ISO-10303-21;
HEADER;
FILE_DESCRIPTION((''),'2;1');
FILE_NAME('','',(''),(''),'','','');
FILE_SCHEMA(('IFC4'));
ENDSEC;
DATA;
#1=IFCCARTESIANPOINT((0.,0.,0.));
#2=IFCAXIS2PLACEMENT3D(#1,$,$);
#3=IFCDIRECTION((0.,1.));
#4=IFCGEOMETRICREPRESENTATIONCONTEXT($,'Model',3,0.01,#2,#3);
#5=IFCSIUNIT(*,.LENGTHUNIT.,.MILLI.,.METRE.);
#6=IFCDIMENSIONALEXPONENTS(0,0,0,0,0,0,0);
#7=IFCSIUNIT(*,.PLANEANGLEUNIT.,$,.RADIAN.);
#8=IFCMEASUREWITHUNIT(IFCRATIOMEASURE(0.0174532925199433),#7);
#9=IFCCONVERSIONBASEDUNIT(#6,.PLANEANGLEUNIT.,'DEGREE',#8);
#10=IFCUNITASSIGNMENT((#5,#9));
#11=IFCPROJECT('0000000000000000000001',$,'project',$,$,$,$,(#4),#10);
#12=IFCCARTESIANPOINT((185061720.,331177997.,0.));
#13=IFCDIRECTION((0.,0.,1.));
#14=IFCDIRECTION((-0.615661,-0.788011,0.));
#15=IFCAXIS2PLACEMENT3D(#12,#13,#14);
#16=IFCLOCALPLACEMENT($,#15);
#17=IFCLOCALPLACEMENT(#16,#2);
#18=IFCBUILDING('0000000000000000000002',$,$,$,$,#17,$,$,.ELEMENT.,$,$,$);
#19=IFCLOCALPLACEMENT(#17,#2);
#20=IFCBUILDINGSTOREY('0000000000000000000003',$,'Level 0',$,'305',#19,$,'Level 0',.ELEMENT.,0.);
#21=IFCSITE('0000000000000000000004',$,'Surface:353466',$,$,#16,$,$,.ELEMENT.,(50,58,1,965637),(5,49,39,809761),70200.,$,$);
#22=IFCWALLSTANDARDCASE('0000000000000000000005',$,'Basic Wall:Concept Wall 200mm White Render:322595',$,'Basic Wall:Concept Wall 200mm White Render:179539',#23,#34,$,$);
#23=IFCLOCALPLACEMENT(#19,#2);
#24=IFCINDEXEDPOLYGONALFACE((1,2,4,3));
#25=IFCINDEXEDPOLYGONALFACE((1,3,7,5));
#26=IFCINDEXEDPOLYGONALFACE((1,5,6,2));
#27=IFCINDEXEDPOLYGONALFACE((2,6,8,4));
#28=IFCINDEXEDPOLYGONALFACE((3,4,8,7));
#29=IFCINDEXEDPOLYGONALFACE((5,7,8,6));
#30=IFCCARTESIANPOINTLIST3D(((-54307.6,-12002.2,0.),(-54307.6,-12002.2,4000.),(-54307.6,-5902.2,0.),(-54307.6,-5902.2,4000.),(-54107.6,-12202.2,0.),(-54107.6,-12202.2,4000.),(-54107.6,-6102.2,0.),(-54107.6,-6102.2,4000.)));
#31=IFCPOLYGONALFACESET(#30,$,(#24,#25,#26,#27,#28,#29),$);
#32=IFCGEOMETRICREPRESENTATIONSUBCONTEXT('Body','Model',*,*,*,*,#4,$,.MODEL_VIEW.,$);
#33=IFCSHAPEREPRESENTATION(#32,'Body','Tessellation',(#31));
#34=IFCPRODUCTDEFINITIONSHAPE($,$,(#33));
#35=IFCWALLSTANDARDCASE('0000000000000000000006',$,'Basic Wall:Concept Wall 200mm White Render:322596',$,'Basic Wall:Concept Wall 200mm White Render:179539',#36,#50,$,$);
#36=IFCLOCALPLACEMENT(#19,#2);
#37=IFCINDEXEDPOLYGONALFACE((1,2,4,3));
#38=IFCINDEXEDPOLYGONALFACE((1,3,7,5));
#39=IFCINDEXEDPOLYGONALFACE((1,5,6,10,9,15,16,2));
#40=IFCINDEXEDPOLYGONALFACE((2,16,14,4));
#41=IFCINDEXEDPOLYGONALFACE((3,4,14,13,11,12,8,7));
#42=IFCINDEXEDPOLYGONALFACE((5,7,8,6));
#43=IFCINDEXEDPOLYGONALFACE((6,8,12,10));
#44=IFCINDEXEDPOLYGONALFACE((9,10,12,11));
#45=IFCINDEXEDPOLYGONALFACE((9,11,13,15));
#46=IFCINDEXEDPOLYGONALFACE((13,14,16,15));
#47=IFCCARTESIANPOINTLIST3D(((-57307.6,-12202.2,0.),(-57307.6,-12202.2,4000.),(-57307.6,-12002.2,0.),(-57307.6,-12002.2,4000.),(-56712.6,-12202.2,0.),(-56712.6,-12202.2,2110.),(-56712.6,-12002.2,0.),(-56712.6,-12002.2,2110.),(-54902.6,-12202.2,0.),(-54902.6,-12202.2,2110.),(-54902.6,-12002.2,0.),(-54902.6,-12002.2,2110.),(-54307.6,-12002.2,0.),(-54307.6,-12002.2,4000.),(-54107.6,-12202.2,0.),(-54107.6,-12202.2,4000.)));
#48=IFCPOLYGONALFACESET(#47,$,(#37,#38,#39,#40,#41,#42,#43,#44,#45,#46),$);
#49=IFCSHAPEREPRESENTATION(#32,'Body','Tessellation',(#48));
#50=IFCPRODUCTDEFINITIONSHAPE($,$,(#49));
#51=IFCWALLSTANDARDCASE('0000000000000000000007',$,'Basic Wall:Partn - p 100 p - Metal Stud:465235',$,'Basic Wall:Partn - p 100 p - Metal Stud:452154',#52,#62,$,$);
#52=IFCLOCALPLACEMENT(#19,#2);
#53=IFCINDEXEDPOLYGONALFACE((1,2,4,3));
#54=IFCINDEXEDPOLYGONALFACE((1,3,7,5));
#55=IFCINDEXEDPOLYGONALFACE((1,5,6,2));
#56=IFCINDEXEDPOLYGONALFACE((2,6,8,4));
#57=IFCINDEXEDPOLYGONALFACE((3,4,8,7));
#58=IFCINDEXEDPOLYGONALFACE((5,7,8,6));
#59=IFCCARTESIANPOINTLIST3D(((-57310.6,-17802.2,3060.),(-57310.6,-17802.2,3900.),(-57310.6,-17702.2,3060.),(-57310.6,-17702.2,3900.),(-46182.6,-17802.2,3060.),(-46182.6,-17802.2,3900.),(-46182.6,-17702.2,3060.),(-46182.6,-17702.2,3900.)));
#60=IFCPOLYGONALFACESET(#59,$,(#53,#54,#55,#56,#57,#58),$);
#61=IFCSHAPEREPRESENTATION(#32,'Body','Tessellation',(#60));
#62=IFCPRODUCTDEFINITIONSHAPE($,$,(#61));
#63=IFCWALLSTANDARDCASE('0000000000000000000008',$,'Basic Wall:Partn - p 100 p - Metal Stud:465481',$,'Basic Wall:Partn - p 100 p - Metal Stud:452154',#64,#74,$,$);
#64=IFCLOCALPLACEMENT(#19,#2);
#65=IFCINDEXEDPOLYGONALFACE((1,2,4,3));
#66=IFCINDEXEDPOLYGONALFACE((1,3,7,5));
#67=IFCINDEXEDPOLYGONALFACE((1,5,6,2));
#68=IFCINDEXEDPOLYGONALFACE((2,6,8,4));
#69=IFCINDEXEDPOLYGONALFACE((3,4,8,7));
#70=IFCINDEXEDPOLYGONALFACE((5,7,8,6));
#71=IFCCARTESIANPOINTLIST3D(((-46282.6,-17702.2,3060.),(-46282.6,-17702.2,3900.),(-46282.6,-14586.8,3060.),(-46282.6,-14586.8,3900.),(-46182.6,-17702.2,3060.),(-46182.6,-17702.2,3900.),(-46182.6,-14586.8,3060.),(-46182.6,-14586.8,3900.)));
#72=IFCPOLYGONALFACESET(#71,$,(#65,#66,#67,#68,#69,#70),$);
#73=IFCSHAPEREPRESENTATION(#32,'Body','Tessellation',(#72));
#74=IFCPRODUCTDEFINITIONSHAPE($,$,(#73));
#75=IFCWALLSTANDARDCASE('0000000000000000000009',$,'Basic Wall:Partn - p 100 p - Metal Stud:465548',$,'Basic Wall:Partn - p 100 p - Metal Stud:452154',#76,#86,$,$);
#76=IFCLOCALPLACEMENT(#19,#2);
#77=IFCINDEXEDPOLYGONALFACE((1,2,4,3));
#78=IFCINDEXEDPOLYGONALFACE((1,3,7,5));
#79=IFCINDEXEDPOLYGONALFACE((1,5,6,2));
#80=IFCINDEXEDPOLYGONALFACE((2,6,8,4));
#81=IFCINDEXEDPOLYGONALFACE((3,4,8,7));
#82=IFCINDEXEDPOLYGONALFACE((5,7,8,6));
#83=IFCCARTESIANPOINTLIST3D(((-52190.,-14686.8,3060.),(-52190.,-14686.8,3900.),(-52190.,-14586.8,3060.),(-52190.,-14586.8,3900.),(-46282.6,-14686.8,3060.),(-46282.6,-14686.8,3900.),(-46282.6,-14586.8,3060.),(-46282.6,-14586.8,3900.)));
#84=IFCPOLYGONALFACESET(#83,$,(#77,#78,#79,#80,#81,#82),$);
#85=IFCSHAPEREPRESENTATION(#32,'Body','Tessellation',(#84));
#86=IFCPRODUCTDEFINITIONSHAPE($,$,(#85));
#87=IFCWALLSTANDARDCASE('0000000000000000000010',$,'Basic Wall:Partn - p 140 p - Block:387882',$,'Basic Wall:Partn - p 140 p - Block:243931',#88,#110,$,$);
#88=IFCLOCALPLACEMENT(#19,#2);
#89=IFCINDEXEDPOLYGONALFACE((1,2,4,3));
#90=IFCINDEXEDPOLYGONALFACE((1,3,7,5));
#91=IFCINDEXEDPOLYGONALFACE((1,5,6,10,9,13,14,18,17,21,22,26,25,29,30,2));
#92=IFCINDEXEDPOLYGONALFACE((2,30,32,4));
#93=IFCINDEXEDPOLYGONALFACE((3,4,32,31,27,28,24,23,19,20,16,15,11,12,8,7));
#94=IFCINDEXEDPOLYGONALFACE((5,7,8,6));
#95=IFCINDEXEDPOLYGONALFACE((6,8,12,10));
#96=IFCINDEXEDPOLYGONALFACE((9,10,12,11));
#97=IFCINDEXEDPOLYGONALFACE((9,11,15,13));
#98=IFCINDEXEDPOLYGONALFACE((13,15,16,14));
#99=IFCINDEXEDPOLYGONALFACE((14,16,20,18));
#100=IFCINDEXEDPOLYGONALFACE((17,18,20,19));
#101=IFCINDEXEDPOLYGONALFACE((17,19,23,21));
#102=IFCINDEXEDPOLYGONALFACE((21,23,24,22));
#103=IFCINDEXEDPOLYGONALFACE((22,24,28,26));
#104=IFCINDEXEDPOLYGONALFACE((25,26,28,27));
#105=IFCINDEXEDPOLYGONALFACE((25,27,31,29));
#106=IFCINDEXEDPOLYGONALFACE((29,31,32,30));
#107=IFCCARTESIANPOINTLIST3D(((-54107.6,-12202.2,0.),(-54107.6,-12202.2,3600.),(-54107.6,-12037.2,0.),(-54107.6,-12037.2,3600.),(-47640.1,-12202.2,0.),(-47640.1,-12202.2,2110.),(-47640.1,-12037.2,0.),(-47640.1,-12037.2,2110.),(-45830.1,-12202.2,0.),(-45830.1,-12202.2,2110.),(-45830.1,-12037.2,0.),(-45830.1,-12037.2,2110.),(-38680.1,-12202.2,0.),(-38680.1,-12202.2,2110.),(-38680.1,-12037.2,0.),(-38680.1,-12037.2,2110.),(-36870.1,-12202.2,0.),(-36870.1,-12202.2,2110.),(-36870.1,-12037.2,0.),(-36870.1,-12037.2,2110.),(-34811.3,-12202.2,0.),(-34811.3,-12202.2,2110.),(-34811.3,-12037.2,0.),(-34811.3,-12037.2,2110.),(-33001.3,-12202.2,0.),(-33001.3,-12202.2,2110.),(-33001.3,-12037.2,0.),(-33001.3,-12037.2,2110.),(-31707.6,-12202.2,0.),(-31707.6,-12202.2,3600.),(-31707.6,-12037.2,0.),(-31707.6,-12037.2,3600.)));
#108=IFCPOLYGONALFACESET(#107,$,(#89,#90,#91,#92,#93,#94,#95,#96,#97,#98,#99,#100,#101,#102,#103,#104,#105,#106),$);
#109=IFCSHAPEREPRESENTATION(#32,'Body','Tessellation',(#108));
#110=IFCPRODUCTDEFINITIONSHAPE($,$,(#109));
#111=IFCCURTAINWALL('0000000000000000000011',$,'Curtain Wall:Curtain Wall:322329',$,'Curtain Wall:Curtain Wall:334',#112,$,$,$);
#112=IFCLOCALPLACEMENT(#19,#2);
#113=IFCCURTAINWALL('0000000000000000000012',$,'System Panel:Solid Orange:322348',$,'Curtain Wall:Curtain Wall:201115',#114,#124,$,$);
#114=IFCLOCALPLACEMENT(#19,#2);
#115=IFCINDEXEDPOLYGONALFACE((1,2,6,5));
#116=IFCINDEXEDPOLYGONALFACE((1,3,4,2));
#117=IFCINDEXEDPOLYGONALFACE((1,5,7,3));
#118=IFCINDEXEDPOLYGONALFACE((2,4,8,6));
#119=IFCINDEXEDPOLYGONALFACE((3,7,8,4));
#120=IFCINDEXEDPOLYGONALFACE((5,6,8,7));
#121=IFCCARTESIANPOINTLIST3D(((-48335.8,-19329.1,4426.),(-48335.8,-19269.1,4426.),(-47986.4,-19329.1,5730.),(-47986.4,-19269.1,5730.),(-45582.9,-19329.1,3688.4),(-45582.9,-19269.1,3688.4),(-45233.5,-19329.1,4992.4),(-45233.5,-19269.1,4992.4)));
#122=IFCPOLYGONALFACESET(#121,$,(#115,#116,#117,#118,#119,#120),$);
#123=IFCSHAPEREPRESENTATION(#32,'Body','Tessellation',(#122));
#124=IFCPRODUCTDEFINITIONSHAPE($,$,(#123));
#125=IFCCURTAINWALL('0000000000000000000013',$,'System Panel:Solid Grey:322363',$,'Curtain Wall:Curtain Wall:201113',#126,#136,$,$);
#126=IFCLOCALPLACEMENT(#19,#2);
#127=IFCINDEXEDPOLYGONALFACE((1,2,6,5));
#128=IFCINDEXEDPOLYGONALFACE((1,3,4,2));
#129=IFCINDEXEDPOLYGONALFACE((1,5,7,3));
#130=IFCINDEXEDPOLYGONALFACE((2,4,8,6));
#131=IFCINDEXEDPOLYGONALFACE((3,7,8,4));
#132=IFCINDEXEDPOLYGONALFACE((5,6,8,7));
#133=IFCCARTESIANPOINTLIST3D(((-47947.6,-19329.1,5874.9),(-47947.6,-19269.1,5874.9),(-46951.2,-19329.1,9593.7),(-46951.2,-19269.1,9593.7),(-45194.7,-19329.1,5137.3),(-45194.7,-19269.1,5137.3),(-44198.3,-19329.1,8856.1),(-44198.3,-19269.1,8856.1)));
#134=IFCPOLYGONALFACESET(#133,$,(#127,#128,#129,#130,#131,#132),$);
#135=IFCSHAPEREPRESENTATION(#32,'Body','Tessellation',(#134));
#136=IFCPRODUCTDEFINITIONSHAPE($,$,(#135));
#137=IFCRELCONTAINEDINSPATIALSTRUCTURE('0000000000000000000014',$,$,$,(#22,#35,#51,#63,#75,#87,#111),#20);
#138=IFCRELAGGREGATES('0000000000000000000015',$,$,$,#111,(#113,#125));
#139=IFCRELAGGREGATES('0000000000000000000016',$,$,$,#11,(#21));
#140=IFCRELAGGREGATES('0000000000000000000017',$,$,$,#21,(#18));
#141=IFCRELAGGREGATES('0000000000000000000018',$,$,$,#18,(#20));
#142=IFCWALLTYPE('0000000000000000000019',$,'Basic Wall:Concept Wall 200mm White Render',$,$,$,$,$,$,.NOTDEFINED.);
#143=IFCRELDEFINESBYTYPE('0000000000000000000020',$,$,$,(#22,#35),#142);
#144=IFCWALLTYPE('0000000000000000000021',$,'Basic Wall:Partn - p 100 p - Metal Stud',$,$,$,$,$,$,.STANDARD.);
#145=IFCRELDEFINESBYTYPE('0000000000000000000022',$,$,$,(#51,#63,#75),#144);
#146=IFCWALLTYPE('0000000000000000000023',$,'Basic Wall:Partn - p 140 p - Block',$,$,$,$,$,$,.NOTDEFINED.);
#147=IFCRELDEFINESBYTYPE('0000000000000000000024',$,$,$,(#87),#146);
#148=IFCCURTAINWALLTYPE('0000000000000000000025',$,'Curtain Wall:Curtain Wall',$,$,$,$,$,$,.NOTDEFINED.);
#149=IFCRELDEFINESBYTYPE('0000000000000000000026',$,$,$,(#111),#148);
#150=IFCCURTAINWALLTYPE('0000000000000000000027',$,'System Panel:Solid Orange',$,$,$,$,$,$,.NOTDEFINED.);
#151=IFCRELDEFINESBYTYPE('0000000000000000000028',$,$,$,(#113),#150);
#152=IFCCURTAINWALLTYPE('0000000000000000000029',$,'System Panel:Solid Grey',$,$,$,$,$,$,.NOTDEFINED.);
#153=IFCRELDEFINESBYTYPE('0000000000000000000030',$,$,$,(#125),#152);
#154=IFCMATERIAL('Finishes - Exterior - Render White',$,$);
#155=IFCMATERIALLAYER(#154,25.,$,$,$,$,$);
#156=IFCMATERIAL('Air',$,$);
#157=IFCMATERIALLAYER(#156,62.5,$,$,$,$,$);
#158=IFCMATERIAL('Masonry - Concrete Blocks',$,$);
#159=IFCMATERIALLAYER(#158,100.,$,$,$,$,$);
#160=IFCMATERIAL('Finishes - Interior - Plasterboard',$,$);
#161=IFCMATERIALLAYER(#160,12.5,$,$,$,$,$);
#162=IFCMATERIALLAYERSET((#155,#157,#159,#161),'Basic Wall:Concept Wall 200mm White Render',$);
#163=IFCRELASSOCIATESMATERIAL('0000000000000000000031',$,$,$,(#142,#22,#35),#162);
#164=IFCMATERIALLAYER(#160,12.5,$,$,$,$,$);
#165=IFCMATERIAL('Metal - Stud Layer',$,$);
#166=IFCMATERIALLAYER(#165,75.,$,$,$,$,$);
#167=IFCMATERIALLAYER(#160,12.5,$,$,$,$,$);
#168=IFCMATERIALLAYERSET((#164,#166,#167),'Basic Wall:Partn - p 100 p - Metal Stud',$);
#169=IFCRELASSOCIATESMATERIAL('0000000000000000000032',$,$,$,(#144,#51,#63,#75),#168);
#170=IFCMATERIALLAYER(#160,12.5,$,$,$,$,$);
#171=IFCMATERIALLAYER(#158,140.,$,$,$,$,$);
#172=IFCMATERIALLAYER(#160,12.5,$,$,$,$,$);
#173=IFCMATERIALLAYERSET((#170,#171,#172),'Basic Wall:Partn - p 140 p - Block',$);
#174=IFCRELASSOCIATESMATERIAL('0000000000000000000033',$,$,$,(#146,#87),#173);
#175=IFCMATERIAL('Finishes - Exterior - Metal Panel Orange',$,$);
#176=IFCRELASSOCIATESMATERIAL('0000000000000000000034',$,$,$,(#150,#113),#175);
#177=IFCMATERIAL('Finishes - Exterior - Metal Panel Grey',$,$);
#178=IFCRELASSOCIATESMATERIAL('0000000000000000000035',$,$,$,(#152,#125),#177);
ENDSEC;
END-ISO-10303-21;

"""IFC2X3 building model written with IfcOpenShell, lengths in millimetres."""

from ifc_helpers import new_model, entity, si_unit, converted_unit, direction, frame, frame_2d, origin, place, context, subcontext, project, spatial, polyline, rectangle, outline, extrude, clip, halfspace, bounded_halfspace, source, transform, mapped, material, layer, layer_set, layer_usage, type_object, type_shapes, element, aggregate, save


model = new_model("IFC2X3")

# Units and contexts
model_context = context("Model", 3, precision=0.01, world=origin(), true_north=direction((0.0, 1.0)))
body_context = subcontext(model_context, "Body", "Model", "MODEL_VIEW")
ifc_project = project(units=[si_unit("LENGTHUNIT", "METRE", prefix="MILLI"), converted_unit("PLANEANGLEUNIT", "DEGREE", entity("IfcRatioMeasure", 0.0174532925199433), si_unit("PLANEANGLEUNIT", "RADIAN"), dimensions=[0, 0, 0, 0, 0, 0, 0])], contexts=[model_context])

# Site, building, storey
site_placement = place(None, frame((185061720.0, 331177997.0, 0.0), z_axis=(0.0, 0.0, 1.0), x_axis=(-0.615661, -0.788011, 0.0)))
site = spatial("IfcSite", under=ifc_project, at=site_placement, Name="Surface:353466", CompositionType="ELEMENT", RefLatitude=(50, 58, 1, 965637), RefLongitude=(5, 49, 39, 809761), RefElevation=70200.0)
building_placement = place(site_placement, origin())
building = spatial("IfcBuilding", under=site, at=building_placement, CompositionType="ELEMENT")
storey_placement = place(building_placement, origin())
storey = spatial("IfcBuildingStorey", under=building, at=storey_placement, Name="Level 0", ObjectType="305", LongName="Level 0", CompositionType="ELEMENT", Elevation=0.0)

# Wall
ifc_material_1 = material(Name="Finishes - Exterior - Render White")
ifc_layer_1 = layer(ifc_material_1, 25.0)
ifc_material_2 = material(Name="Air")
ifc_layer_2 = layer(ifc_material_2, 62.5)
ifc_material_3 = material(Name="Masonry - Concrete Blocks")
ifc_layer_3 = layer(ifc_material_3, 100.0)
ifc_material_4 = material(Name="Finishes - Interior - Plasterboard")
ifc_layer_4 = layer(ifc_material_4, 12.5)
ifc_layer_set_1 = layer_set([ifc_layer_1, ifc_layer_2, ifc_layer_3, ifc_layer_4], Name="Basic Wall:Concept Wall 200mm White Render")
ifc_layer_usage_1 = layer_usage(ifc_layer_set_1, "AXIS2", "POSITIVE", -100.0)
wall_type_1 = type_object("IfcWallType", Name="Basic Wall:Concept Wall 200mm White Render", PredefinedType="NOTDEFINED", material=ifc_layer_set_1)
wall_1_placement = place(storey_placement, frame((-54207.6, -5902.2, 0.0), z_axis=(0.0, 0.0, 1.0), x_axis=(0.0, -1.0, 0.0)))
element("IfcWallStandardCase", 1, at=wall_1_placement, inside=storey, type_object=wall_type_1, material=ifc_layer_usage_1, Name="Basic Wall:Concept Wall 200mm White Render:322595", ObjectType="Basic Wall:Concept Wall 200mm White Render:179539", context=body_context, shape_type="Clipping", body=[
    clip(extrude(outline(polyline([(6100.0, -100.0), (6300.0, 100.0), (6135.0, 100.0), (200.0, 100.0), (0.0, -100.0), (6100.0, -100.0)])), origin(), (0.0, 0.0, 1.0), 4000.0), halfspace(origin(), True)),
])

# Wall, openings
ifc_layer_usage_2 = layer_usage(ifc_layer_set_1, "AXIS2", "POSITIVE", -100.0)
wall_2_placement = place(storey_placement, frame((-54107.6, -12102.2, 0.0), z_axis=(0.0, 0.0, 1.0), x_axis=(-1.0, 0.0, 0.0)))
wall_2 = element("IfcWallStandardCase", 2, at=wall_2_placement, inside=storey, type_object=wall_type_1, material=ifc_layer_usage_2, Name="Basic Wall:Concept Wall 200mm White Render:322596", ObjectType="Basic Wall:Concept Wall 200mm White Render:179539", context=body_context, shape_type="Clipping", body=[
    clip(extrude(outline(polyline([(200.0, -100.0), (3200.0, -100.0), (3200.0, 100.0), (0.0, 100.0), (200.0, -100.0)])), origin(), (0.0, 0.0, 1.0), 4000.0), halfspace(origin(), True)),
])
opening_1_placement = place(wall_2_placement, origin())
element("IfcOpeningElement", 3, at=opening_1_placement, cuts=wall_2, ObjectType="Opening", context=body_context, shape_type="SweptSolid", body=[
    extrude(rectangle(XDim=2110.0, YDim=1810.0, at=frame_2d((0.0, 0.0), x_axis=(1.0, 0.0))), frame((1700.0, -1624.0, 1055.0), z_axis=(0.0, 1.0, 0.0), x_axis=(0.0, 0.0, -1.0)), (0.0, 0.0, 1.0), 3048.0),
])
opening_2_placement = place(wall_2_placement, frame((2605.0, 100.0, 0.0)))
element("IfcOpeningElement", 4, at=opening_2_placement, cuts=wall_2, ObjectType="Opening", context=body_context, shape_type="SweptSolid", body=[
    extrude(rectangle(XDim=2110.0, YDim=1810.0, at=frame_2d((1055.0, 905.0), x_axis=(-1.0, 0.0))), frame((0.0, 0.0, 0.0), z_axis=(0.0, -1.0, 0.0), x_axis=(0.0, 0.0, 1.0)), (0.0, 0.0, 1.0), 200.0),
])

# Walls
ifc_layer_5 = layer(ifc_material_4, 12.5)
ifc_material_5 = material(Name="Metal - Stud Layer")
ifc_layer_6 = layer(ifc_material_5, 75.0)
ifc_layer_7 = layer(ifc_material_4, 12.5)
ifc_layer_set_2 = layer_set([ifc_layer_5, ifc_layer_6, ifc_layer_7], Name="Basic Wall:Partn - p 100 p - Metal Stud")
ifc_layer_usage_3 = layer_usage(ifc_layer_set_2, "AXIS2", "NEGATIVE", 50.0)
wall_type_2 = type_object("IfcWallType", Name="Basic Wall:Partn - p 100 p - Metal Stud", PredefinedType="STANDARD", material=ifc_layer_set_2)
wall_3_placement = place(storey_placement, frame((-46182.6, -17752.2, 3060.0), z_axis=(0.0, 0.0, 1.0), x_axis=(-1.0, 0.0, 0.0)))
element("IfcWallStandardCase", 5, at=wall_3_placement, inside=storey, type_object=wall_type_2, material=ifc_layer_usage_3, Name="Basic Wall:Partn - p 100 p - Metal Stud:465235", ObjectType="Basic Wall:Partn - p 100 p - Metal Stud:452154", context=body_context, shape_type="SweptSolid", body=[
    extrude(rectangle(XDim=11128.0, YDim=100.0, at=frame_2d((5564.0, 0.0), x_axis=(-1.0, 0.0))), origin(), (0.0, 0.0, 1.0), 840.0),
])
ifc_layer_usage_4 = layer_usage(ifc_layer_set_2, "AXIS2", "NEGATIVE", 50.0)
wall_4_placement = place(storey_placement, frame((-46232.6, -14586.8, 3060.0), z_axis=(0.0, 0.0, 1.0), x_axis=(0.0, -1.0, 0.0)))
element("IfcWallStandardCase", 6, at=wall_4_placement, inside=storey, type_object=wall_type_2, material=ifc_layer_usage_4, Name="Basic Wall:Partn - p 100 p - Metal Stud:465481", ObjectType="Basic Wall:Partn - p 100 p - Metal Stud:452154", context=body_context, shape_type="SweptSolid", body=[
    extrude(rectangle(XDim=3115.5, YDim=100.0, at=frame_2d((1557.7, 0.0), x_axis=(-1.0, 0.0))), origin(), (0.0, 0.0, 1.0), 840.0),
])
ifc_layer_usage_5 = layer_usage(ifc_layer_set_2, "AXIS2", "NEGATIVE", 50.0)
wall_5_placement = place(storey_placement, frame((-52190.0, -14636.8, 3060.0)))
element("IfcWallStandardCase", 7, at=wall_5_placement, inside=storey, type_object=wall_type_2, material=ifc_layer_usage_5, Name="Basic Wall:Partn - p 100 p - Metal Stud:465548", ObjectType="Basic Wall:Partn - p 100 p - Metal Stud:452154", context=body_context, shape_type="SweptSolid", body=[
    extrude(rectangle(XDim=5907.5, YDim=100.0, at=frame_2d((2953.7, 0.0), x_axis=(-1.0, 0.0))), origin(), (0.0, 0.0, 1.0), 840.0),
])

# Wall, openings
ifc_layer_8 = layer(ifc_material_4, 12.5)
ifc_layer_9 = layer(ifc_material_3, 140.0)
ifc_layer_10 = layer(ifc_material_4, 12.5)
ifc_layer_set_3 = layer_set([ifc_layer_8, ifc_layer_9, ifc_layer_10], Name="Basic Wall:Partn - p 140 p - Block")
ifc_layer_usage_6 = layer_usage(ifc_layer_set_3, "AXIS2", "POSITIVE", -82.5)
wall_type_3 = type_object("IfcWallType", Name="Basic Wall:Partn - p 140 p - Block", PredefinedType="NOTDEFINED", material=ifc_layer_set_3)
wall_6_placement = place(storey_placement, frame((-54107.6, -12119.7, 0.0)))
wall_6 = element("IfcWallStandardCase", 8, at=wall_6_placement, inside=storey, type_object=wall_type_3, material=ifc_layer_usage_6, Name="Basic Wall:Partn - p 140 p - Block:387882", ObjectType="Basic Wall:Partn - p 140 p - Block:243931", context=body_context, shape_type="Clipping", body=[
    clip(extrude(rectangle(XDim=22400.0, YDim=165.0, at=frame_2d((11200.0, 0.0), x_axis=(-1.0, 0.0))), origin(), (0.0, 0.0, 1.0), 3600.0), bounded_halfspace(frame((0.0, -82.5, 3600.0), z_axis=(0.0, 0.0, -1.0), x_axis=(1.0, 0.0, 0.0)), True, frame((0.0, -82.5, 3600.0)), polyline([(0.0, 0.0), (22400.0, 0.0), (22400.0, 165.0), (17602.5, 165.0), (17437.5, 165.0), (9042.5, 165.0), (8877.5, 165.0), (0.0, 165.0), (0.0, 0.0)]))),
])
opening_3_placement = place(wall_6_placement, origin())
element("IfcOpeningElement", 9, at=opening_3_placement, cuts=wall_6, ObjectType="Opening", context=body_context, shape_type="SweptSolid", body=[
    extrude(rectangle(XDim=2110.0, YDim=1810.0, at=frame_2d((0.0, 0.0), x_axis=(0.0, 1.0))), frame((7372.5, -1441.5, 1055.0), z_axis=(0.0, 1.0, 0.0), x_axis=(-1.0, 0.0, 0.0)), (0.0, 0.0, 1.0), 3048.0),
])
opening_4_placement = place(wall_6_placement, origin())
element("IfcOpeningElement", 10, at=opening_4_placement, cuts=wall_6, ObjectType="Opening", context=body_context, shape_type="SweptSolid", body=[
    extrude(rectangle(XDim=2110.0, YDim=1810.0, at=frame_2d((0.0, 0.0), x_axis=(0.0, 1.0))), frame((16332.5, -1606.5, 1055.0), z_axis=(0.0, 1.0, 0.0), x_axis=(-1.0, 0.0, 0.0)), (0.0, 0.0, 1.0), 3048.0),
])
opening_5_placement = place(wall_6_placement, origin())
element("IfcOpeningElement", 11, at=opening_5_placement, cuts=wall_6, ObjectType="Opening", context=body_context, shape_type="SweptSolid", body=[
    extrude(rectangle(XDim=2110.0, YDim=1810.0, at=frame_2d((0.0, 0.0), x_axis=(0.0, 1.0))), frame((20201.2, -1441.5, 1055.0), z_axis=(0.0, 1.0, 0.0), x_axis=(-1.0, 0.0, 0.0)), (0.0, 0.0, 1.0), 3048.0),
])
opening_6_placement = place(wall_6_placement, frame((8277.5, 82.5, 0.0)))
element("IfcOpeningElement", 12, at=opening_6_placement, cuts=wall_6, ObjectType="Opening", context=body_context, shape_type="SweptSolid", body=[
    extrude(rectangle(XDim=2110.0, YDim=1810.0, at=frame_2d((1055.0, 905.0), x_axis=(1.0, 0.0))), frame((0.0, 0.0, 0.0), z_axis=(0.0, -1.0, 0.0), x_axis=(0.0, 0.0, 1.0)), (0.0, 0.0, 1.0), 165.0),
])
opening_7_placement = place(wall_6_placement, frame((15427.5, -82.5, 0.0)))
element("IfcOpeningElement", 13, at=opening_7_placement, cuts=wall_6, ObjectType="Opening", context=body_context, shape_type="SweptSolid", body=[
    extrude(rectangle(XDim=2110.0, YDim=1810.0, at=frame_2d((1055.0, 905.0), x_axis=(1.0, 0.0))), frame((0.0, 0.0, 0.0), z_axis=(0.0, 1.0, 0.0), x_axis=(0.0, 0.0, 1.0)), (0.0, 0.0, 1.0), 165.0),
])
opening_8_placement = place(wall_6_placement, frame((21106.2, 82.5, 0.0)))
element("IfcOpeningElement", 14, at=opening_8_placement, cuts=wall_6, ObjectType="Opening", context=body_context, shape_type="SweptSolid", body=[
    extrude(rectangle(XDim=2110.0, YDim=1810.0, at=frame_2d((1055.0, 905.0), x_axis=(1.0, 0.0))), frame((0.0, 0.0, 0.0), z_axis=(0.0, -1.0, 0.0), x_axis=(0.0, 0.0, 1.0)), (0.0, 0.0, 1.0), 165.0),
])

# Curtain walls
curtain_wall_type_1 = type_object("IfcCurtainWallType", Name="Curtain Wall:Curtain Wall", PredefinedType="NOTDEFINED")
curtain_wall_1_placement = place(storey_placement, origin())
curtain_wall_1 = element("IfcCurtainWall", 15, at=curtain_wall_1_placement, inside=storey, type_object=curtain_wall_type_1, Name="Curtain Wall:Curtain Wall:322329", ObjectType="Curtain Wall:Curtain Wall:334")
ifc_material_6 = material(Name="Finishes - Exterior - Metal Panel Grey")
ifc_material_7 = material(Name="Finishes - Exterior - Metal Panel Orange")
curtain_wall_type_2 = type_object("IfcCurtainWallType", Name="System Panel:Solid Orange", PredefinedType="NOTDEFINED", material=ifc_material_7)
shared_shape_1 = source(origin(), body_context, "Body", "SweptSolid", [
    extrude(rectangle(XDim=60.0, YDim=2850.0, at=frame_2d((0.0, 0.0), x_axis=(1.0, 0.0))), frame((0.0, 0.0, 0.0), z_axis=(0.0, 0.0, 1.0), x_axis=(0.0, 1.0, 0.0)), (0.0, 0.0, 1.0), 1350.0),
])
type_shapes(curtain_wall_type_2, [shared_shape_1])
curtain_wall_2_placement = place(storey_placement, frame((-46959.4, -19299.1, 4057.2), z_axis=(0.258819, 0.0, 0.965926), x_axis=(-0.965926, 0.0, 0.258819)))
curtain_wall_2 = element("IfcCurtainWall", 16, at=curtain_wall_2_placement, type_object=curtain_wall_type_2, material=ifc_material_7, Name="System Panel:Solid Orange:322348", ObjectType="Curtain Wall:Curtain Wall:201115", context=body_context, shape_type="MappedRepresentation", body=[
    mapped(shared_shape_1, transform((0.0, 0.0, 0.0), scale=1.0)),
])
curtain_wall_type_3 = type_object("IfcCurtainWallType", Name="System Panel:Solid Grey", PredefinedType="NOTDEFINED", material=ifc_material_6)
shared_shape_2 = source(origin(), body_context, "Body", "SweptSolid", [
    extrude(rectangle(XDim=60.0, YDim=2850.0, at=frame_2d((0.0, 0.0), x_axis=(1.0, 0.0))), frame((0.0, 0.0, 0.0), z_axis=(0.0, 0.0, 1.0), x_axis=(0.0, 1.0, 0.0)), (0.0, 0.0, 1.0), 3850.0),
])
type_shapes(curtain_wall_type_3, [shared_shape_2])
curtain_wall_3_placement = place(storey_placement, frame((-46571.2, -19299.1, 5506.1), z_axis=(0.258819, 0.0, 0.965926), x_axis=(-0.965926, 0.0, 0.258819)))
curtain_wall_3 = element("IfcCurtainWall", 17, at=curtain_wall_3_placement, type_object=curtain_wall_type_3, material=ifc_material_6, Name="System Panel:Solid Grey:322363", ObjectType="Curtain Wall:Curtain Wall:201113", context=body_context, shape_type="MappedRepresentation", body=[
    mapped(shared_shape_2, transform((0.0, 0.0, 0.0), scale=1.0)),
])
aggregate(curtain_wall_1, [curtain_wall_2, curtain_wall_3])

save(model, "model.ifc")
